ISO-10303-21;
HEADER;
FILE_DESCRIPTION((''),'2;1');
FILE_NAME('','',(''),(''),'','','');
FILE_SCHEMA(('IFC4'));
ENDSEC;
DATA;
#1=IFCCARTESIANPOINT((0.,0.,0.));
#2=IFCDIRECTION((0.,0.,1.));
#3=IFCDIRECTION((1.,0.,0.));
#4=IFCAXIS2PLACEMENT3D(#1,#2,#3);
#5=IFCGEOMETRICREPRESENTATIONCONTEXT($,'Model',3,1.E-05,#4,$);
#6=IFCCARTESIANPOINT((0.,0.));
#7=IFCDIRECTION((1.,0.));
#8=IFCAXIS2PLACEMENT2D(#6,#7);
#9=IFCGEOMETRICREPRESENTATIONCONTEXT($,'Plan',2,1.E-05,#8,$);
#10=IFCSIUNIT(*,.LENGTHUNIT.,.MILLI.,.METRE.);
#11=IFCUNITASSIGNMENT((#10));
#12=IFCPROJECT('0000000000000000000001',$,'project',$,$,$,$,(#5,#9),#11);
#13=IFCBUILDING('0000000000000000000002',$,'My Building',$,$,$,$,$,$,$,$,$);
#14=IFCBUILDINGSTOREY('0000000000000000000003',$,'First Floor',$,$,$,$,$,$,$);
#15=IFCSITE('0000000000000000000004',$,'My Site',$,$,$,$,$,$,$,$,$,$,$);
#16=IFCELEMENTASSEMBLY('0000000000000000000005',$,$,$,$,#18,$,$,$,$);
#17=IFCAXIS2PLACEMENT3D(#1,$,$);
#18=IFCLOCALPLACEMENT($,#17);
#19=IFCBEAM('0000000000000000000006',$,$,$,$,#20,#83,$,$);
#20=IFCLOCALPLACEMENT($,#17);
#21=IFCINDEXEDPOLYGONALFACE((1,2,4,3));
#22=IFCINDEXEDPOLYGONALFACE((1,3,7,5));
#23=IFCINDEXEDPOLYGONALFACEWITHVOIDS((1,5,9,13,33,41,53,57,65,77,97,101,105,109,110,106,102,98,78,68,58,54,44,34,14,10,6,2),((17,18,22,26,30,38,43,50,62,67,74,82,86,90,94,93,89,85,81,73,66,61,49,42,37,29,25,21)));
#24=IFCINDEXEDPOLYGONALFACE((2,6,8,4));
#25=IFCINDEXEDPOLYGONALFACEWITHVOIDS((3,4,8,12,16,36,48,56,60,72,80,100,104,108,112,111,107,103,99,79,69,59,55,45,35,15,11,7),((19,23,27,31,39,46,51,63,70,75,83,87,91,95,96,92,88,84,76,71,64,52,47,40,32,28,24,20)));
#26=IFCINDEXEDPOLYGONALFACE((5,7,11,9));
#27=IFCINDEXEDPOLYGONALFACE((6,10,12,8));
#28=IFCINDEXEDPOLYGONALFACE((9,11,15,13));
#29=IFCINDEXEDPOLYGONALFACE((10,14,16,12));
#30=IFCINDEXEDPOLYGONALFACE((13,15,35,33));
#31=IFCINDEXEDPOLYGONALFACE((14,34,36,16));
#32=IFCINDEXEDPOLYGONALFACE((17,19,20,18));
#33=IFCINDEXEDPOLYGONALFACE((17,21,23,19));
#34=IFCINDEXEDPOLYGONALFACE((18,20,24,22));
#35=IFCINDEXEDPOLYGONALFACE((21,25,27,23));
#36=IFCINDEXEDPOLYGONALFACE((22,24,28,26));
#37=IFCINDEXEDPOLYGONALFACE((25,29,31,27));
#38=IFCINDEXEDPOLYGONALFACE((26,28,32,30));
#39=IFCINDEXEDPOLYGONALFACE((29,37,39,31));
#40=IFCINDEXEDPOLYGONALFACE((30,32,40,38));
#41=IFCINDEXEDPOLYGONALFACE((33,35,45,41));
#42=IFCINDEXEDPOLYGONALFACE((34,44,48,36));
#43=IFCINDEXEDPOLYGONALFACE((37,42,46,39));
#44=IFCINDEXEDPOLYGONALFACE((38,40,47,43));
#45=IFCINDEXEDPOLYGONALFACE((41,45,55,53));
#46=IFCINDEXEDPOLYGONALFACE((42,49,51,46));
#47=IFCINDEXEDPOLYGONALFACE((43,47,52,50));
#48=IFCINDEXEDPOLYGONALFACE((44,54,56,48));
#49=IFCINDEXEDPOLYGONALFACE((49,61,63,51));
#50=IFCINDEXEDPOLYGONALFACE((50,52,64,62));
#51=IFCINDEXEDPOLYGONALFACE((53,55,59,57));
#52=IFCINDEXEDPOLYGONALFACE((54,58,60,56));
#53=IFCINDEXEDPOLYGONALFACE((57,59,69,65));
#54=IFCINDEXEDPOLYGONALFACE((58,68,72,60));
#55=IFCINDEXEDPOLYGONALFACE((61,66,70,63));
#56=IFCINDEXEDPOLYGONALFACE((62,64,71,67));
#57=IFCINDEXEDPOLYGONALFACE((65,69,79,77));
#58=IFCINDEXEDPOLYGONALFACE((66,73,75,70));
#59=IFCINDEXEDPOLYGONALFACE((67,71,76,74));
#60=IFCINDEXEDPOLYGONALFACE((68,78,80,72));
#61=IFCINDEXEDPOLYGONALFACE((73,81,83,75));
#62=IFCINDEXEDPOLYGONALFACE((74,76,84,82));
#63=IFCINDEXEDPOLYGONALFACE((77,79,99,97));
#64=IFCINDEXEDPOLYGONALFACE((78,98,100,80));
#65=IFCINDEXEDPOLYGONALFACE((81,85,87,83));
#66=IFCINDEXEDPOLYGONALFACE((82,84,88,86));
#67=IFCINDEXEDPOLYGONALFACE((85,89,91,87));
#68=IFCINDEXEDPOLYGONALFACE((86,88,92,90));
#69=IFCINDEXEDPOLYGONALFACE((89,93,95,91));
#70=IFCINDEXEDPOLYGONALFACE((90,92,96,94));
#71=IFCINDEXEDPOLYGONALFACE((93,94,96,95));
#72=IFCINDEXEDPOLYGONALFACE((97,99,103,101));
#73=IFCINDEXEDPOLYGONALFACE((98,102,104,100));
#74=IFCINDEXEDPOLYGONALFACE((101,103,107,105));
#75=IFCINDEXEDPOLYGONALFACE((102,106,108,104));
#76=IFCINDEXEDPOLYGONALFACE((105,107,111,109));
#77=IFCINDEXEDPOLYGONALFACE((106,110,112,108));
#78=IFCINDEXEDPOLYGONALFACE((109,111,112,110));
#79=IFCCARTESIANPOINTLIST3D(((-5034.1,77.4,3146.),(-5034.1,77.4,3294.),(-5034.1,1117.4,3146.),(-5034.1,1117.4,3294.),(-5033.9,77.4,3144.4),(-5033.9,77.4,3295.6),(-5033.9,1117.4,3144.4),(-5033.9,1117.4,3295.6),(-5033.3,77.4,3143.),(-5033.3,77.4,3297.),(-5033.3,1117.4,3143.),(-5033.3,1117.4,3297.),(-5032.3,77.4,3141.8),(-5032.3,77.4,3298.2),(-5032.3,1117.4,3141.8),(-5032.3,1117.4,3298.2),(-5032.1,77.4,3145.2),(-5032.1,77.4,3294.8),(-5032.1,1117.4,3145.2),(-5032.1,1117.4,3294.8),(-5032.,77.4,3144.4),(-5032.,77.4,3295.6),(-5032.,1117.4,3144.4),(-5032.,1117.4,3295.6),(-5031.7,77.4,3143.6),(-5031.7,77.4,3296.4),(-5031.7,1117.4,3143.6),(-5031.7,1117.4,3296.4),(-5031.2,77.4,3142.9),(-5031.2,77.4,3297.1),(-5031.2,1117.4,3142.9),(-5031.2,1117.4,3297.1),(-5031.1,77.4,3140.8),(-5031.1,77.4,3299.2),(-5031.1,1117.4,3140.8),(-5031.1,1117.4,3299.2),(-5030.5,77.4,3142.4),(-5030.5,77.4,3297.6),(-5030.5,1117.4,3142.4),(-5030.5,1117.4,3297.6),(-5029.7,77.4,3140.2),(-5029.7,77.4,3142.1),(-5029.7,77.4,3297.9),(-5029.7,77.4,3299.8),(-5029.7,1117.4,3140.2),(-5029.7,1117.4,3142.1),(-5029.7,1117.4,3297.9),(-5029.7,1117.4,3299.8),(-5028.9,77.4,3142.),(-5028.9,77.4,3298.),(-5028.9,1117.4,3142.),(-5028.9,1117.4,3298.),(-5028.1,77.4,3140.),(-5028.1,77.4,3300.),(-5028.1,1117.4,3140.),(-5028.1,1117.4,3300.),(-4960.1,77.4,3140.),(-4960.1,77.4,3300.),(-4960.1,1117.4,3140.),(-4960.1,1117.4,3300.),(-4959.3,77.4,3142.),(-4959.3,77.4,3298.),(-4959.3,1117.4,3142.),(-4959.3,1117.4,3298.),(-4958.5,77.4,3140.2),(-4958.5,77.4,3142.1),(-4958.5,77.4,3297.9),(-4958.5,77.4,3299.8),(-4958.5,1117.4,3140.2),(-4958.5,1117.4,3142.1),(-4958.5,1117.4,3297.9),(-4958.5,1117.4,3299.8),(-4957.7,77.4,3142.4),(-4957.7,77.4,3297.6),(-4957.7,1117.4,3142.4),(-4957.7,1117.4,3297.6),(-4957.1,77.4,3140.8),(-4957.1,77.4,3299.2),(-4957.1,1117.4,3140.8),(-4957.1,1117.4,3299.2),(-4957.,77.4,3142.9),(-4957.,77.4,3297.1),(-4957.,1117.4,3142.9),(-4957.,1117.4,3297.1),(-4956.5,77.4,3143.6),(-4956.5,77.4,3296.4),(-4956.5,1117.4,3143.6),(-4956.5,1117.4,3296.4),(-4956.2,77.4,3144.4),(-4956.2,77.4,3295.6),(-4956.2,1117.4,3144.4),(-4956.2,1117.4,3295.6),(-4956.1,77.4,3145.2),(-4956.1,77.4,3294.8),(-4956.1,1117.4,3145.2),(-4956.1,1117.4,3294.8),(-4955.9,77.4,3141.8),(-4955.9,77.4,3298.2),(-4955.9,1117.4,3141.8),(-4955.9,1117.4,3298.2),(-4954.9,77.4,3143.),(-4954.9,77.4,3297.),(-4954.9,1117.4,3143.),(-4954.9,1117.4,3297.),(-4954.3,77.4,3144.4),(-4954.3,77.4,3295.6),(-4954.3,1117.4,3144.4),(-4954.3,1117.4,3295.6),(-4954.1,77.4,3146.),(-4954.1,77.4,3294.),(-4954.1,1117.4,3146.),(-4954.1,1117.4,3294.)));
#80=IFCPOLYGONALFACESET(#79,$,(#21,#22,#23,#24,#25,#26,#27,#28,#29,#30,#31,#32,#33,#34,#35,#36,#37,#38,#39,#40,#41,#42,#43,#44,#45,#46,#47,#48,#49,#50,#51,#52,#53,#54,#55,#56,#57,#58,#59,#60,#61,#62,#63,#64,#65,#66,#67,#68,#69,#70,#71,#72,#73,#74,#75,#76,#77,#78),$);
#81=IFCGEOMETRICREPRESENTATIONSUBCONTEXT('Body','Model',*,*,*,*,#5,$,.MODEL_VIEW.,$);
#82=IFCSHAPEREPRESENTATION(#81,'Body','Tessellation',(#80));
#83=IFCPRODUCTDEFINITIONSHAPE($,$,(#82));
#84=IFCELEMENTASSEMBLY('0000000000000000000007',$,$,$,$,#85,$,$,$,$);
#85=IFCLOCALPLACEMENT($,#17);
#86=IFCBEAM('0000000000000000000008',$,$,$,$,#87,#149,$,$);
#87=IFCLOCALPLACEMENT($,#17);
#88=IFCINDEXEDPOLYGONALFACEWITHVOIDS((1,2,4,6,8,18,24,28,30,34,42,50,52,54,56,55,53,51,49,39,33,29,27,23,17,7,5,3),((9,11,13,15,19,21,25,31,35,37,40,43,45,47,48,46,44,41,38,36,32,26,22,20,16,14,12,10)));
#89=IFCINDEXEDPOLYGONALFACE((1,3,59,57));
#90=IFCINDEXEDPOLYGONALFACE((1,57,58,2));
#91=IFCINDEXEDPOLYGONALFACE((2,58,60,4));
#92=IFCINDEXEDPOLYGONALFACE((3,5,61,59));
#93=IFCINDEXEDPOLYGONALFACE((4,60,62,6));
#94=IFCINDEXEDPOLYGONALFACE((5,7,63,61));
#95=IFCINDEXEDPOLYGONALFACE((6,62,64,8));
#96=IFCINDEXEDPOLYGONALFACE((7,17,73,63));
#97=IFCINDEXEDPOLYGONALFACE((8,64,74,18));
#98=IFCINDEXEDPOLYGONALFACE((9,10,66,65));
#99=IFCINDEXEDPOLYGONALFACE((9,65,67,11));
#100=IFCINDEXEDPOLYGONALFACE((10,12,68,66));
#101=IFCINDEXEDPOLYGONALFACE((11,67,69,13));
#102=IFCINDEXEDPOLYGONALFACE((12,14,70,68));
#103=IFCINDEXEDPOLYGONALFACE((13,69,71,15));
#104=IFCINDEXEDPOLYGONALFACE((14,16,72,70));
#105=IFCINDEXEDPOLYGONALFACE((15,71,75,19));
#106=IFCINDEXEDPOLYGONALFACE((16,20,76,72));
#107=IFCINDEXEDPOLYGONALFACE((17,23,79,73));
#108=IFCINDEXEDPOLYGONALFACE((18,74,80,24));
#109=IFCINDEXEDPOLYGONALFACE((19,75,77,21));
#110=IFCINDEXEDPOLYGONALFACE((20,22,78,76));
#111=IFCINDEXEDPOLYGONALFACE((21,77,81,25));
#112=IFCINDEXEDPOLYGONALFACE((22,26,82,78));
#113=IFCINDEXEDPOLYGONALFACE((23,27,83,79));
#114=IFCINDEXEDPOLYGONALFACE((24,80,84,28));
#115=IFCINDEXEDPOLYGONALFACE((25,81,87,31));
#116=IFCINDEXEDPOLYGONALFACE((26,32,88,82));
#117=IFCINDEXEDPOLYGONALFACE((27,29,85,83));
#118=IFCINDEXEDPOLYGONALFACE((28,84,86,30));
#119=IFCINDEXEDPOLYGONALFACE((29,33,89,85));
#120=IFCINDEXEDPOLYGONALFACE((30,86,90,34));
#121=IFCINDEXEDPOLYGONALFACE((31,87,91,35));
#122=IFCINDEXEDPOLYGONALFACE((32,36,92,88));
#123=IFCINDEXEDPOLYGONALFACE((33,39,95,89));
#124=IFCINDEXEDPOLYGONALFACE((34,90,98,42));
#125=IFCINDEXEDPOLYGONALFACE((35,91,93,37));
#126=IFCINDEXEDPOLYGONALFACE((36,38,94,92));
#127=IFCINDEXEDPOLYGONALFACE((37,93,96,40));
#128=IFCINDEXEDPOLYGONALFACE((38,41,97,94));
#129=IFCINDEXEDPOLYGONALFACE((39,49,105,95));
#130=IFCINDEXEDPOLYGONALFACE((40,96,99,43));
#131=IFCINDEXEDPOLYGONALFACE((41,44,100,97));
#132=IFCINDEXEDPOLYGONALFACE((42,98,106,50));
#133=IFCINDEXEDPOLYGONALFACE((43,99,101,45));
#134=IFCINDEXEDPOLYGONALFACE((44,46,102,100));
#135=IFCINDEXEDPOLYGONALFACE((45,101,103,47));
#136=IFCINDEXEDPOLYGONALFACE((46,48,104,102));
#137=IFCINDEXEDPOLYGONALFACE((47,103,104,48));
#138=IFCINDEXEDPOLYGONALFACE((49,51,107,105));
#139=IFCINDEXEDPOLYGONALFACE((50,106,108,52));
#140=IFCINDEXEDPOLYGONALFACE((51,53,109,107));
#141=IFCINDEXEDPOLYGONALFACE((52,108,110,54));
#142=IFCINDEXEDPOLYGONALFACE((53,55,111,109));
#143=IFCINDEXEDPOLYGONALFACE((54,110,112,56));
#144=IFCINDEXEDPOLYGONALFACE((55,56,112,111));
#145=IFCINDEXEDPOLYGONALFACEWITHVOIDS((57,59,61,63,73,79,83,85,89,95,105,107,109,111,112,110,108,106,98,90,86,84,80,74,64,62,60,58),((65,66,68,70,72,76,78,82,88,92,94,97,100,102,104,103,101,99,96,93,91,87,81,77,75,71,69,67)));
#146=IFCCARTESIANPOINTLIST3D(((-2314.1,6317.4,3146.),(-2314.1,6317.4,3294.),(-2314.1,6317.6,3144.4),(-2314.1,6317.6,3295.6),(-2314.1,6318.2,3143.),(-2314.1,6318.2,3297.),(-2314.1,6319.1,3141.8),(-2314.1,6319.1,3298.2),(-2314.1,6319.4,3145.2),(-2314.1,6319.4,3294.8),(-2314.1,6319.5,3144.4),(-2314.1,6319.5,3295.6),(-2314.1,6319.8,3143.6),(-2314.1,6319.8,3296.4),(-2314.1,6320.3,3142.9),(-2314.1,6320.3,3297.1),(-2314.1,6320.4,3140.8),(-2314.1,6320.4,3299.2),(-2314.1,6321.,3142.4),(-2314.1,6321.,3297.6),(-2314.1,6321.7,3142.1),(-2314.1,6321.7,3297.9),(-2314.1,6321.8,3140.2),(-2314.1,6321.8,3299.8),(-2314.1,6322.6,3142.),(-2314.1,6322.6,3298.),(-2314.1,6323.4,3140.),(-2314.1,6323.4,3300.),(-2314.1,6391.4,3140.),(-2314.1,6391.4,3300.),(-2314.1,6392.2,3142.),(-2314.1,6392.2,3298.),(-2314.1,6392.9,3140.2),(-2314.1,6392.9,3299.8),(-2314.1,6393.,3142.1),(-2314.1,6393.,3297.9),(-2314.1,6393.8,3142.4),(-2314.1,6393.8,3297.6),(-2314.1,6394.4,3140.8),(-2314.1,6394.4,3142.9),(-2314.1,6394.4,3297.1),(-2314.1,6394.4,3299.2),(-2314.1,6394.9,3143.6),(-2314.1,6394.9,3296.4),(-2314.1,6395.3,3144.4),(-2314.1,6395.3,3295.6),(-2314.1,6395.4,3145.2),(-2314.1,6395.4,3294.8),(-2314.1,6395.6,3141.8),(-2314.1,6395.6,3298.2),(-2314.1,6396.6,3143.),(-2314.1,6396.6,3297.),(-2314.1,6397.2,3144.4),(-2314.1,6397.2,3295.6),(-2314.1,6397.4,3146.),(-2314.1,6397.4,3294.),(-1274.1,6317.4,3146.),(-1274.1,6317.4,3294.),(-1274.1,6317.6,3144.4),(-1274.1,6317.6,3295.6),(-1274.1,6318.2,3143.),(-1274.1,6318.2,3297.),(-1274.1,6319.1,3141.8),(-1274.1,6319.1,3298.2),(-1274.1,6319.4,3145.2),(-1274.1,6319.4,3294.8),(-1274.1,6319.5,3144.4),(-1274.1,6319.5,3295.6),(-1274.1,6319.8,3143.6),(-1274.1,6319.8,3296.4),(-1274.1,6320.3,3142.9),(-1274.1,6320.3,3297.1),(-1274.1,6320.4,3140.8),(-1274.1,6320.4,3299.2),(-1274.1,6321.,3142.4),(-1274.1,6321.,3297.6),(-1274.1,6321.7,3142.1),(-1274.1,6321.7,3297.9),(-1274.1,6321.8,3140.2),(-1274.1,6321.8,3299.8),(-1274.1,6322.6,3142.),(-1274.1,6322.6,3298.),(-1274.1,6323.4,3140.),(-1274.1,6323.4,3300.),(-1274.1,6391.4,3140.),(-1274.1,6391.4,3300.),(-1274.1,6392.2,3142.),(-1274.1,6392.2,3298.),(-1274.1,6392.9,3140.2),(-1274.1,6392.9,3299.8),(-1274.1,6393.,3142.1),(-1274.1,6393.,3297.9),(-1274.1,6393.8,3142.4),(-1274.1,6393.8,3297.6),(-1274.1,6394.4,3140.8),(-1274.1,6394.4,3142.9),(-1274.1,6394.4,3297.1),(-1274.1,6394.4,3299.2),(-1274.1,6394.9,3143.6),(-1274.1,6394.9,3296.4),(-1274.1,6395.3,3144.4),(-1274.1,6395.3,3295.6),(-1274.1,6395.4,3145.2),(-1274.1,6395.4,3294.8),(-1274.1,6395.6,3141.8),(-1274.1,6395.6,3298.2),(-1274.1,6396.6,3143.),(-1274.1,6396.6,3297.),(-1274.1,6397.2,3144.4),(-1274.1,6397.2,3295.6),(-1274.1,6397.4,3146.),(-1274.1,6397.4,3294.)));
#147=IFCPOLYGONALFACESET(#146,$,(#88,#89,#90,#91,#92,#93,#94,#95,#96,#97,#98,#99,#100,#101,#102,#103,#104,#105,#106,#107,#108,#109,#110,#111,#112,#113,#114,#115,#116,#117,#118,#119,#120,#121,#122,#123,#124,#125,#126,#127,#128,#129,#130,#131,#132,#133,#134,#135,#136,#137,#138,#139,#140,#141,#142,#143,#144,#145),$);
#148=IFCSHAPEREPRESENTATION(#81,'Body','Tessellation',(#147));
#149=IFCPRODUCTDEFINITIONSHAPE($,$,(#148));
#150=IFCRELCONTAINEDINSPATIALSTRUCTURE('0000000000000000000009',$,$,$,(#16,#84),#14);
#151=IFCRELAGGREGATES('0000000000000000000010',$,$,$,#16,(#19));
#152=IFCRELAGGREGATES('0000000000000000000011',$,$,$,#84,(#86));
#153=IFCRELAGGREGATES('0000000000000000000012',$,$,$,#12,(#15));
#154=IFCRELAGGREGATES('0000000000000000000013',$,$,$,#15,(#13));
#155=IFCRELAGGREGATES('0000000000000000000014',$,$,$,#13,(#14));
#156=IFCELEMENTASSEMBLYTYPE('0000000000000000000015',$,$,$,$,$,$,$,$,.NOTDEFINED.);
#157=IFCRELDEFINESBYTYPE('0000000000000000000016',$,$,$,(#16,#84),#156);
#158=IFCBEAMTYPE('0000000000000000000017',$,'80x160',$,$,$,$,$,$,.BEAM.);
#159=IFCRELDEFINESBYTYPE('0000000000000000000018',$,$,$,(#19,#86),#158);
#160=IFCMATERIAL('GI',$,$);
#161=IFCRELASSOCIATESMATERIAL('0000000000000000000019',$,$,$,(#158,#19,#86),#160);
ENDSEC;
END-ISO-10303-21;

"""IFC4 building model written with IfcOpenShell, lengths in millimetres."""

from ifc_helpers import new_model, si_unit, frame, origin_with_axes, origin_2d_with_axis, place, context, subcontext, project, spatial, hollow_rectangle, extrude, material, material_profile, profile_set, profile_usage, type_object, element, aggregate, save


model = new_model("IFC4")

# Units and contexts
model_context = context("Model", 3, precision=1e-05, world=origin_with_axes())
plan_context = context("Plan", 2, precision=1e-05, world=origin_2d_with_axis())
body_context = subcontext(model_context, "Body", "Model", "MODEL_VIEW")
ifc_project = project(units=[si_unit("LENGTHUNIT", "METRE", prefix="MILLI")], contexts=[model_context, plan_context])

# Site, building, storey
site = spatial("IfcSite", under=ifc_project, Name="My Site")
building = spatial("IfcBuilding", under=site, Name="My Building")
storey = spatial("IfcBuildingStorey", under=building, Name="First Floor")

# Element assemblies, beams
element_assembly_type = type_object("IfcElementAssemblyType", PredefinedType="NOTDEFINED")
ifc_material = material(Name="GI")
ifc_material_profile = material_profile(ifc_material, hollow_rectangle(XDim=80.0, YDim=160.0, WallThickness=2.0, InnerFilletRadius=3.2, OuterFilletRadius=6.0))
ifc_profile_set = profile_set([ifc_material_profile], Name="80x160 GI Rectangular Hollow")
beam_type = type_object("IfcBeamType", Name="80x160", PredefinedType="BEAM", material=ifc_profile_set)
assembly_1_placement = place(None, frame((-4994.1, -2.6, 3220.0), z_axis=(0.0, 1.0, 0.0), x_axis=(1.0, 0.0, 0.0)))
assembly_1 = element("IfcElementAssembly", 1, at=assembly_1_placement, inside=storey, type_object=element_assembly_type)
ifc_profile_usage_1 = profile_usage(ifc_profile_set)
beam_1_placement = place(assembly_1_placement, frame((0.0, 0.0, 80.0), z_axis=(0.0, 0.0, 1.0), x_axis=(1.0, 0.0, 0.0)))
beam_1 = element("IfcBeam", 2, at=beam_1_placement, type_object=beam_type, material=ifc_profile_usage_1, context=body_context, shape_type="SweptSolid", body=[
    extrude(hollow_rectangle(XDim=80.0, YDim=160.0, WallThickness=2.0, InnerFilletRadius=3.2, OuterFilletRadius=6.0), origin_with_axes(), (0.0, 0.0, 1.0), 1040.0),
])
aggregate(assembly_1, [beam_1])
assembly_2_placement = place(None, frame((-2394.1, 6357.4, 3220.0), z_axis=(1.0, 0.0, 0.0), x_axis=(0.0, 1.0, 0.0)))
assembly_2 = element("IfcElementAssembly", 3, at=assembly_2_placement, inside=storey, type_object=element_assembly_type)
ifc_profile_usage_2 = profile_usage(ifc_profile_set)
beam_2_placement = place(assembly_2_placement, frame((0.0, 0.0, 80.0), z_axis=(0.0, 0.0, 1.0), x_axis=(1.0, 0.0, 0.0)))
beam_2 = element("IfcBeam", 4, at=beam_2_placement, type_object=beam_type, material=ifc_profile_usage_2, context=body_context, shape_type="SweptSolid", body=[
    extrude(hollow_rectangle(XDim=80.0, YDim=160.0, WallThickness=2.0, InnerFilletRadius=3.2, OuterFilletRadius=6.0), origin_with_axes(), (0.0, 0.0, 1.0), 1040.0),
])
aggregate(assembly_2, [beam_2])

save(model, "model.ifc")
